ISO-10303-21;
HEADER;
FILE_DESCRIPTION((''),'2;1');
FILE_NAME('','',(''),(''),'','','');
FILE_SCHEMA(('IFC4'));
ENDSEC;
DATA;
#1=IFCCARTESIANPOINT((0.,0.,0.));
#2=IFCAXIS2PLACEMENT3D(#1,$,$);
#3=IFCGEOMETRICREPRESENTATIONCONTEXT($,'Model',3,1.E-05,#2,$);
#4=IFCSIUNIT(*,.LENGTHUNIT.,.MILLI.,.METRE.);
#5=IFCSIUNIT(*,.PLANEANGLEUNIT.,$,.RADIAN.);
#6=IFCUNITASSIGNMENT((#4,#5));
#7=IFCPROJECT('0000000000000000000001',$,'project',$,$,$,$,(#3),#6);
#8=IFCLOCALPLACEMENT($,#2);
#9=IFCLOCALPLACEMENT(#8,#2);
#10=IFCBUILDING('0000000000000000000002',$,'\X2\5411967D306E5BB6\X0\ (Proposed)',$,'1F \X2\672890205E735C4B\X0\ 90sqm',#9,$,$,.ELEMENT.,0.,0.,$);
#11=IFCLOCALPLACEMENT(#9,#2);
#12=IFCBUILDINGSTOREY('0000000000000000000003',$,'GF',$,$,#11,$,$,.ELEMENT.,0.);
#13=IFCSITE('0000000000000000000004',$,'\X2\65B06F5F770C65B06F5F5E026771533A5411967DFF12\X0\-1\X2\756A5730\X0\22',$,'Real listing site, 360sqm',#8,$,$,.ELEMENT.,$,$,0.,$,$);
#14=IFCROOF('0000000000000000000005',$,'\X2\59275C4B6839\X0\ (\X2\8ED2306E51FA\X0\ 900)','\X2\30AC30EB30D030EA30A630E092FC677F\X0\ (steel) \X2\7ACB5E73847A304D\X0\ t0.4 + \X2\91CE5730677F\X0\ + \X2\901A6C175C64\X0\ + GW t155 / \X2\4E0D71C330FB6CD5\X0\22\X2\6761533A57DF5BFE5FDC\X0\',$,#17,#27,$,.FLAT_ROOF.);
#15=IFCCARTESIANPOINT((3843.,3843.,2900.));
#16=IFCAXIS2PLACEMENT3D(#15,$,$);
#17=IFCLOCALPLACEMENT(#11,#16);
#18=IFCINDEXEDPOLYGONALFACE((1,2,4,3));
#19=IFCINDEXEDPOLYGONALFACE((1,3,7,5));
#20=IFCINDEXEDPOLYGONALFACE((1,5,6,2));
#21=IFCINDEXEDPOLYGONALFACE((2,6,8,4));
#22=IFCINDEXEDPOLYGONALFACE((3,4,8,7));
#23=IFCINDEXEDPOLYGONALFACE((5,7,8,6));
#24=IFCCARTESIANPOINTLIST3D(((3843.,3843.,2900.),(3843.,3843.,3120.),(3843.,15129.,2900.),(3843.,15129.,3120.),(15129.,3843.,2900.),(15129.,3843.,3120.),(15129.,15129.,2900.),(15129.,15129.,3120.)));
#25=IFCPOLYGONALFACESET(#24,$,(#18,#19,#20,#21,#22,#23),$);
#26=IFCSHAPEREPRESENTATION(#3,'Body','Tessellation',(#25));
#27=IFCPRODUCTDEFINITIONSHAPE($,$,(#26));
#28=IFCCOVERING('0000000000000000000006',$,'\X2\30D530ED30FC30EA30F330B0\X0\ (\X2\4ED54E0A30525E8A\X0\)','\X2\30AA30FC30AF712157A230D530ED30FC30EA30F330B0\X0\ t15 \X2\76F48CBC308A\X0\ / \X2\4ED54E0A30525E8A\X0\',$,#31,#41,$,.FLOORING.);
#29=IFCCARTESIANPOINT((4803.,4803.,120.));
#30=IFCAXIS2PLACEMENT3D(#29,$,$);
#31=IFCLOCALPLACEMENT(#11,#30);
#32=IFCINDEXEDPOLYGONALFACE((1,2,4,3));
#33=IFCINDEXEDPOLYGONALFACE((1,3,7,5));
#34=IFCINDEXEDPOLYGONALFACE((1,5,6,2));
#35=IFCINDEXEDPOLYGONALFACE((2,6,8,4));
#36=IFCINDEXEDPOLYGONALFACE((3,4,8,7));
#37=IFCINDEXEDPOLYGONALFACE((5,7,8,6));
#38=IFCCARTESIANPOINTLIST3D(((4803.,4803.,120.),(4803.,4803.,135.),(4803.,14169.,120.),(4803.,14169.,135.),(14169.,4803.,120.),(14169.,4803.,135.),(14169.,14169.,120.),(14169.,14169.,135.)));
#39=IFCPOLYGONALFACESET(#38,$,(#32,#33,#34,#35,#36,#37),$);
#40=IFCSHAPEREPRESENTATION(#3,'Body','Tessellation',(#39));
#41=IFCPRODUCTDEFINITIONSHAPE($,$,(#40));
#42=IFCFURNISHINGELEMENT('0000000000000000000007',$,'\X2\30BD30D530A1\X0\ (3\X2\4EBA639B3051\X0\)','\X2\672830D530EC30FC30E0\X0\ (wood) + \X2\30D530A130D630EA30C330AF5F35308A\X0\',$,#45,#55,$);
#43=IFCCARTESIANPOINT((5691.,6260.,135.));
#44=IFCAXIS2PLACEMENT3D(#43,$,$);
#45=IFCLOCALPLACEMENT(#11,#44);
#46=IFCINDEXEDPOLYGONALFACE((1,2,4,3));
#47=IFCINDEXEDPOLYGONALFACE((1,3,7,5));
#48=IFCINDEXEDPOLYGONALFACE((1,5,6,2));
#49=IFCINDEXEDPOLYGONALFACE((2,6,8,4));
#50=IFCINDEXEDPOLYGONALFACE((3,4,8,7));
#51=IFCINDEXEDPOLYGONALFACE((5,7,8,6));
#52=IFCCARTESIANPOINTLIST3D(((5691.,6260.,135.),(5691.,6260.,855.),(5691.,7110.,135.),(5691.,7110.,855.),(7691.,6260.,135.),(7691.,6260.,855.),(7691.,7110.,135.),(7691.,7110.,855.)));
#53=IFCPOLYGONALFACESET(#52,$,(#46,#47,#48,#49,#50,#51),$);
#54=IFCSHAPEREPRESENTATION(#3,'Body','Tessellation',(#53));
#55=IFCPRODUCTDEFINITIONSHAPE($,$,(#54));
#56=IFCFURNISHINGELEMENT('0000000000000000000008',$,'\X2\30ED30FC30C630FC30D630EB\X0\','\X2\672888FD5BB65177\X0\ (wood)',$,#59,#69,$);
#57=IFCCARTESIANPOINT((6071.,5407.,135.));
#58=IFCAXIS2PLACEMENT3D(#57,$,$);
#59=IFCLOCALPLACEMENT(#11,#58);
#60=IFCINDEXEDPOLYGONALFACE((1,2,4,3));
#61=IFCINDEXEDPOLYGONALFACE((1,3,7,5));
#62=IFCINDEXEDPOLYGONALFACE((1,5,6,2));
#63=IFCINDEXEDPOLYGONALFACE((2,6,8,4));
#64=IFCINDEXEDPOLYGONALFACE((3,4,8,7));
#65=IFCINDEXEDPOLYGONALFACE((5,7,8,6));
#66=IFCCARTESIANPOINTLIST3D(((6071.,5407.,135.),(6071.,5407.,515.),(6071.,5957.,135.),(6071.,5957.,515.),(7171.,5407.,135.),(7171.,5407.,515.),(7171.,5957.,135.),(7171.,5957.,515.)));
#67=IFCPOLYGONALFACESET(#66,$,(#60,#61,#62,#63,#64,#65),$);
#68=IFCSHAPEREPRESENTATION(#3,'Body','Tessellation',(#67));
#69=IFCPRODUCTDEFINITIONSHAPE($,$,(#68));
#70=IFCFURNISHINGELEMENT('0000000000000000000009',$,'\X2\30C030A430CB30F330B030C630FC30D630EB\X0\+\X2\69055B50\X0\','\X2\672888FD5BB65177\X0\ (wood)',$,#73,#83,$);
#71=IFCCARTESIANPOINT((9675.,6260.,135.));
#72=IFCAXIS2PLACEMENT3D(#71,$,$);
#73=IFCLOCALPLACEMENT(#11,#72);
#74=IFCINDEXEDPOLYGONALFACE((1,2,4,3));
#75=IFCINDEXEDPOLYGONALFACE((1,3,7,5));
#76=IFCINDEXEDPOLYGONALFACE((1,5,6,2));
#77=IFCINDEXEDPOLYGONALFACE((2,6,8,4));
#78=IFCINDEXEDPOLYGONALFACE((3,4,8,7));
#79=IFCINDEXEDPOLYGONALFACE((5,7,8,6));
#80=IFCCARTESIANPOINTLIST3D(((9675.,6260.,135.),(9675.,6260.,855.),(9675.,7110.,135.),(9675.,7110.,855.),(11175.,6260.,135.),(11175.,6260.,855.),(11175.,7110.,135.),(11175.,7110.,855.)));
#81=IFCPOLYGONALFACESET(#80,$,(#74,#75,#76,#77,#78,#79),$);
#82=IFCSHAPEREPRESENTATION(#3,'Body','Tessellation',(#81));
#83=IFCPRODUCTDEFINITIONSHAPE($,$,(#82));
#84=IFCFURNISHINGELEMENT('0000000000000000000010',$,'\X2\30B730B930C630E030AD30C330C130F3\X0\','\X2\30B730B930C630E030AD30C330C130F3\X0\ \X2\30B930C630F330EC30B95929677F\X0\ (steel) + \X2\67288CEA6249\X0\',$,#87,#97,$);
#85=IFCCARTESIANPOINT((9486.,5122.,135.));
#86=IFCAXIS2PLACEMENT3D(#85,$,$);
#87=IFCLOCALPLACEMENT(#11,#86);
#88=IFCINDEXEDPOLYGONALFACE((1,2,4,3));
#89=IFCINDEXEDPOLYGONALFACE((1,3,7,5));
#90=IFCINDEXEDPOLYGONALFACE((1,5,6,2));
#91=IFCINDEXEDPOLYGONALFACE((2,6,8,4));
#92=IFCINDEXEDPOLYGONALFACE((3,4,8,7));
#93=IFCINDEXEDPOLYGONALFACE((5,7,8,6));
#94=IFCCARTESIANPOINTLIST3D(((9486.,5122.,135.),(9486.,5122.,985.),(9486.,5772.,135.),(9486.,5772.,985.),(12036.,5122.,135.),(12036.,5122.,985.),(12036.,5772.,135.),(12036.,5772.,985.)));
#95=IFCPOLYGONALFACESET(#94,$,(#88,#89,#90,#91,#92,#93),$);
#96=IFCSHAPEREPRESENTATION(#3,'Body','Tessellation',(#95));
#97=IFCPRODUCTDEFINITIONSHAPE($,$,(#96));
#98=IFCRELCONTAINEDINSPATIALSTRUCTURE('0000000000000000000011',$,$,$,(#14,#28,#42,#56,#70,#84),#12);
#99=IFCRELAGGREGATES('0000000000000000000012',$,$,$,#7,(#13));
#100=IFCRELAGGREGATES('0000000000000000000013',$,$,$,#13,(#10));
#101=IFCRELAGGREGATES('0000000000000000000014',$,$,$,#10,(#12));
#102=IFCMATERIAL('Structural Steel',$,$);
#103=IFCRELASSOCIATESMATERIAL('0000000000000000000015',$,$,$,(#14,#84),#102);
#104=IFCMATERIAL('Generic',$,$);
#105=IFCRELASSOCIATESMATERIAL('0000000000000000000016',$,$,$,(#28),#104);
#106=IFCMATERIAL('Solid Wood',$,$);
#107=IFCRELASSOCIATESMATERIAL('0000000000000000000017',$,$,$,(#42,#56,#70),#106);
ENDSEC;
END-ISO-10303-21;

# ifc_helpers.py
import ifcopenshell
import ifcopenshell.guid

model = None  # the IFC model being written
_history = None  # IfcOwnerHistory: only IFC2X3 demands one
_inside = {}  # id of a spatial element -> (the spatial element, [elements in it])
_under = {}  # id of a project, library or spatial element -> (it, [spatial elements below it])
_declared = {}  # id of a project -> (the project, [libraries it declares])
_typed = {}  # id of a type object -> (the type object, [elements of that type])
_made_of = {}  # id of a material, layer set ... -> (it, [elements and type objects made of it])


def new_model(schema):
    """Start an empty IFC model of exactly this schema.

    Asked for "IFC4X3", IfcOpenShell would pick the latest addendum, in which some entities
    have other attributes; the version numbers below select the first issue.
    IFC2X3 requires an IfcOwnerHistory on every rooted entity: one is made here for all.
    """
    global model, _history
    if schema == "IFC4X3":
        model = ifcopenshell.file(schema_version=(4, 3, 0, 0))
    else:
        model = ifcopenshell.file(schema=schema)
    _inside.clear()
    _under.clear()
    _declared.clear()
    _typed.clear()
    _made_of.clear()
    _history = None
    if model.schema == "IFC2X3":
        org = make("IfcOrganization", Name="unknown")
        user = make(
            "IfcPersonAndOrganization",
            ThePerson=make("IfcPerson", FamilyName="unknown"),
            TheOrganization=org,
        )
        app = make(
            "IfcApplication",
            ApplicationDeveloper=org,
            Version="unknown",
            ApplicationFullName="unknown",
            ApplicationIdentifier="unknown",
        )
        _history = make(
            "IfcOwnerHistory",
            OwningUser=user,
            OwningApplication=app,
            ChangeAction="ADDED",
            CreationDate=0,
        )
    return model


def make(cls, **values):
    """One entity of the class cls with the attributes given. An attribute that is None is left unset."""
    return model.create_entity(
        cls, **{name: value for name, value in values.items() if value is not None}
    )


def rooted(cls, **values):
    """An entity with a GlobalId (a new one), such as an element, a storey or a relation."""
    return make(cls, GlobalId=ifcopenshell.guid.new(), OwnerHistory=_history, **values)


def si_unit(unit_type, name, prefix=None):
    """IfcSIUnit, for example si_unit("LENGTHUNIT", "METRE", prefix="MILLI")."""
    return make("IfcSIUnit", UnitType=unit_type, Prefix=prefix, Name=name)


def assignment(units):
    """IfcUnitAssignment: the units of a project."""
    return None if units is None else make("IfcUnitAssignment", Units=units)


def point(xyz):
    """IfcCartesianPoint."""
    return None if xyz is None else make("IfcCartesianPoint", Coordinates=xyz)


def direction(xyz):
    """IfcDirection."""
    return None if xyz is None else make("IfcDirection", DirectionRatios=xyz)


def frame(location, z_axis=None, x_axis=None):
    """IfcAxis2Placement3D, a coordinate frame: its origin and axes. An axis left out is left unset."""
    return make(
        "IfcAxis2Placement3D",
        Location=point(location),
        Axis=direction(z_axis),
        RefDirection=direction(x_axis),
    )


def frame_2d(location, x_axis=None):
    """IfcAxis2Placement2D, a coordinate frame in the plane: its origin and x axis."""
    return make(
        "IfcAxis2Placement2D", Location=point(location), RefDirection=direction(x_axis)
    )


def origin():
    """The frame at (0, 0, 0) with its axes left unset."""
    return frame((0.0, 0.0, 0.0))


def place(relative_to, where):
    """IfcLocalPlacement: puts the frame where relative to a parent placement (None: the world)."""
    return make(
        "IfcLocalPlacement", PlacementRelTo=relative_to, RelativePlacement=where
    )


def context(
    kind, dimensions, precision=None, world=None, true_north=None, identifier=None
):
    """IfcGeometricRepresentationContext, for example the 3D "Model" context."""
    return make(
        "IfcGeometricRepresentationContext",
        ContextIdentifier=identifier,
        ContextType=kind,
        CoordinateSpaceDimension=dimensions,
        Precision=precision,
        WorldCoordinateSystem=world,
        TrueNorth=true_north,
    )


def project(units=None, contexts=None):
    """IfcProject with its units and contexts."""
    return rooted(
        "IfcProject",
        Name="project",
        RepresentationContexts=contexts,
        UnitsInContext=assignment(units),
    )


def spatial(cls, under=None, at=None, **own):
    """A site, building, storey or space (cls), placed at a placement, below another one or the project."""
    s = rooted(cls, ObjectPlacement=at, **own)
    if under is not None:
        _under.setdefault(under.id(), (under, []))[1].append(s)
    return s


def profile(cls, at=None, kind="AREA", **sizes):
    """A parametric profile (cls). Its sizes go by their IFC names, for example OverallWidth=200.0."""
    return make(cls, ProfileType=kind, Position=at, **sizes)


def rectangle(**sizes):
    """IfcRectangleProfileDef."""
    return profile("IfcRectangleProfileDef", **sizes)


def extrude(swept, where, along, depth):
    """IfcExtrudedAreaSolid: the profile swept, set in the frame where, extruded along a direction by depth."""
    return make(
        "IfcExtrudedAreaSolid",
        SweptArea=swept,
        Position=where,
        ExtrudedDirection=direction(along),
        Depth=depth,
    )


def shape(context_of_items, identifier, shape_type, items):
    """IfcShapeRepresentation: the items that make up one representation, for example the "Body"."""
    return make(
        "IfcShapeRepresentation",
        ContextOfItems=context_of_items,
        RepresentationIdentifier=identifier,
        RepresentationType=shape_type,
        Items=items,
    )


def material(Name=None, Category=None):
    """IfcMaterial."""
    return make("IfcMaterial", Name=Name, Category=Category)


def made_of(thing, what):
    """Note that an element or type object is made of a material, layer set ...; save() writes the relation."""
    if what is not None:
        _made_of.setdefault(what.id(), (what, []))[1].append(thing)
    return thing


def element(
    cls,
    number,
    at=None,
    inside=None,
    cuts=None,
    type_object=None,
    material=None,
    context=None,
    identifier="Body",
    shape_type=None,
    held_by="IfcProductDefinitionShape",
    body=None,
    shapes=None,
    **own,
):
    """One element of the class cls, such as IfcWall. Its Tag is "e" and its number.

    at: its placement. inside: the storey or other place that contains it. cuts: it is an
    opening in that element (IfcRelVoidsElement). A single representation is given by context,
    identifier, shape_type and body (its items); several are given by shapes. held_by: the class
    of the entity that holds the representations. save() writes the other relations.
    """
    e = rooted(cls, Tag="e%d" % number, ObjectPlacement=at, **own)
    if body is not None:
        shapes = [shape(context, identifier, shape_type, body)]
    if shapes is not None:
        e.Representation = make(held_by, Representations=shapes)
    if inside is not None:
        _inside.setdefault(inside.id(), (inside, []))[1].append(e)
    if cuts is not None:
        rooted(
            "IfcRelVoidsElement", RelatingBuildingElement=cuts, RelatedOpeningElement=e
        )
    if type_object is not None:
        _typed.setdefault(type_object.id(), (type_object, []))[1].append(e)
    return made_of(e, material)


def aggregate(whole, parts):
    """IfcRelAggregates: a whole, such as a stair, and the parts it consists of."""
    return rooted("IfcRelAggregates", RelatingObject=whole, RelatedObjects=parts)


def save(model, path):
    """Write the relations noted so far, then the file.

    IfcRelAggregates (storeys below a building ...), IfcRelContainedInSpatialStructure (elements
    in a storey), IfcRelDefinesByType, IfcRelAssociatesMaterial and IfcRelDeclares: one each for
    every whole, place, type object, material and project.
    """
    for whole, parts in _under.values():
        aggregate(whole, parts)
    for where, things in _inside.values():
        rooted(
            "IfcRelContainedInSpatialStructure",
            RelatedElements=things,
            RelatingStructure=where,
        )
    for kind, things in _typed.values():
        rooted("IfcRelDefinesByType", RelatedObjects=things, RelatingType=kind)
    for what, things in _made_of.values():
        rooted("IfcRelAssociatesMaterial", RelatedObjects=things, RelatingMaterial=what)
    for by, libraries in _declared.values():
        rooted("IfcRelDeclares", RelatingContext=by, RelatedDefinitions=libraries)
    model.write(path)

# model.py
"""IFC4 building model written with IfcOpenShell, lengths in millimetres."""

from ifc_helpers import new_model, si_unit, frame, frame_2d, origin, place, context, project, spatial, rectangle, extrude, material, element, save


model = new_model("IFC4")

# Units and contexts
model_context = context("Model", 3, precision=1e-05, world=origin())
ifc_project = project(units=[si_unit("LENGTHUNIT", "METRE", prefix="MILLI"), si_unit("PLANEANGLEUNIT", "RADIAN")], contexts=[model_context])

# Site, building, storey
site_placement = place(None, origin())
site = spatial("IfcSite", under=ifc_project, at=site_placement, Name="新潟県新潟市東区向陽２-1番地22", ObjectType="Real listing site, 360sqm", CompositionType="ELEMENT", RefElevation=0.0)
building_placement = place(site_placement, origin())
building = spatial("IfcBuilding", under=site, at=building_placement, Name="向陽の家 (Proposed)", ObjectType="1F 木造平屋 90sqm", CompositionType="ELEMENT", ElevationOfRefHeight=0.0, ElevationOfTerrain=0.0)
storey_placement = place(building_placement, origin())
storey = spatial("IfcBuildingStorey", under=building, at=storey_placement, Name="GF", CompositionType="ELEMENT", Elevation=0.0)

# Shared definitions
ifc_material_1 = material(Name="Solid Wood")

# Roof
ifc_material_2 = material(Name="Structural Steel")
roof_placement = place(storey_placement, frame((3843.0, 3843.0, 2900.0)))
element("IfcRoof", 1, at=roof_placement, inside=storey, material=ifc_material_2, Name="大屋根 (軒の出 900)", Description="ガルバリウム鋼板 (steel) 立平葺き t0.4 + 野地板 + 通気層 + GW t155 / 不燃・法22条区域対応", PredefinedType="FLAT_ROOF", context=model_context, shape_type="SweptSolid", body=[
    extrude(rectangle(XDim=11286.0, YDim=11286.0, at=frame_2d((5643.0, 5643.0))), frame((3843.0, 3843.0, 2900.0)), (0.0, 0.0, 1.0), 220.0),
])

# Covering
ifc_material_3 = material(Name="Generic")
covering_placement = place(storey_placement, frame((4803.0, 4803.0, 120.0)))
element("IfcCovering", 2, at=covering_placement, inside=storey, material=ifc_material_3, Name="フローリング (仕上げ床)", Description="オーク無垢フローリング t15 直貼り / 仕上げ床", PredefinedType="FLOORING", context=model_context, shape_type="SweptSolid", body=[
    extrude(rectangle(XDim=9366.0, YDim=9366.0, at=frame_2d((4683.0, 4683.0))), frame((4803.0, 4803.0, 120.0)), (0.0, 0.0, 1.0), 15.0),
])

# Furnishing elements
furnishing_1_placement = place(storey_placement, frame((5691.0, 6260.0, 135.0)))
element("IfcFurnishingElement", 3, at=furnishing_1_placement, inside=storey, material=ifc_material_1, Name="ソファ (3人掛け)", Description="木フレーム (wood) + ファブリック張り", context=model_context, shape_type="SweptSolid", body=[
    extrude(rectangle(XDim=2000.0, YDim=850.0, at=frame_2d((1000.0, 425.0))), frame((5691.0, 6260.0, 135.0)), (0.0, 0.0, 1.0), 720.0),
])
furnishing_2_placement = place(storey_placement, frame((6071.0, 5407.0, 135.0)))
element("IfcFurnishingElement", 4, at=furnishing_2_placement, inside=storey, material=ifc_material_1, Name="ローテーブル", Description="木製家具 (wood)", context=model_context, shape_type="SweptSolid", body=[
    extrude(rectangle(XDim=1100.0, YDim=550.0, at=frame_2d((550.0, 275.0))), frame((6071.0, 5407.0, 135.0)), (0.0, 0.0, 1.0), 380.0),
])
furnishing_3_placement = place(storey_placement, frame((9675.0, 6260.0, 135.0)))
element("IfcFurnishingElement", 5, at=furnishing_3_placement, inside=storey, material=ifc_material_1, Name="ダイニングテーブル+椅子", Description="木製家具 (wood)", context=model_context, shape_type="SweptSolid", body=[
    extrude(rectangle(XDim=1500.0, YDim=850.0, at=frame_2d((750.0, 425.0))), frame((9675.0, 6260.0, 135.0)), (0.0, 0.0, 1.0), 720.0),
])
furnishing_4_placement = place(storey_placement, frame((9486.0, 5122.0, 135.0)))
element("IfcFurnishingElement", 6, at=furnishing_4_placement, inside=storey, material=ifc_material_2, Name="システムキッチン", Description="システムキッチン ステンレス天板 (steel) + 木質扉", context=model_context, shape_type="SweptSolid", body=[
    extrude(rectangle(XDim=2550.0, YDim=650.0, at=frame_2d((1275.0, 325.0))), frame((9486.0, 5122.0, 135.0)), (0.0, 0.0, 1.0), 850.0),
])

save(model, "model.ifc")
